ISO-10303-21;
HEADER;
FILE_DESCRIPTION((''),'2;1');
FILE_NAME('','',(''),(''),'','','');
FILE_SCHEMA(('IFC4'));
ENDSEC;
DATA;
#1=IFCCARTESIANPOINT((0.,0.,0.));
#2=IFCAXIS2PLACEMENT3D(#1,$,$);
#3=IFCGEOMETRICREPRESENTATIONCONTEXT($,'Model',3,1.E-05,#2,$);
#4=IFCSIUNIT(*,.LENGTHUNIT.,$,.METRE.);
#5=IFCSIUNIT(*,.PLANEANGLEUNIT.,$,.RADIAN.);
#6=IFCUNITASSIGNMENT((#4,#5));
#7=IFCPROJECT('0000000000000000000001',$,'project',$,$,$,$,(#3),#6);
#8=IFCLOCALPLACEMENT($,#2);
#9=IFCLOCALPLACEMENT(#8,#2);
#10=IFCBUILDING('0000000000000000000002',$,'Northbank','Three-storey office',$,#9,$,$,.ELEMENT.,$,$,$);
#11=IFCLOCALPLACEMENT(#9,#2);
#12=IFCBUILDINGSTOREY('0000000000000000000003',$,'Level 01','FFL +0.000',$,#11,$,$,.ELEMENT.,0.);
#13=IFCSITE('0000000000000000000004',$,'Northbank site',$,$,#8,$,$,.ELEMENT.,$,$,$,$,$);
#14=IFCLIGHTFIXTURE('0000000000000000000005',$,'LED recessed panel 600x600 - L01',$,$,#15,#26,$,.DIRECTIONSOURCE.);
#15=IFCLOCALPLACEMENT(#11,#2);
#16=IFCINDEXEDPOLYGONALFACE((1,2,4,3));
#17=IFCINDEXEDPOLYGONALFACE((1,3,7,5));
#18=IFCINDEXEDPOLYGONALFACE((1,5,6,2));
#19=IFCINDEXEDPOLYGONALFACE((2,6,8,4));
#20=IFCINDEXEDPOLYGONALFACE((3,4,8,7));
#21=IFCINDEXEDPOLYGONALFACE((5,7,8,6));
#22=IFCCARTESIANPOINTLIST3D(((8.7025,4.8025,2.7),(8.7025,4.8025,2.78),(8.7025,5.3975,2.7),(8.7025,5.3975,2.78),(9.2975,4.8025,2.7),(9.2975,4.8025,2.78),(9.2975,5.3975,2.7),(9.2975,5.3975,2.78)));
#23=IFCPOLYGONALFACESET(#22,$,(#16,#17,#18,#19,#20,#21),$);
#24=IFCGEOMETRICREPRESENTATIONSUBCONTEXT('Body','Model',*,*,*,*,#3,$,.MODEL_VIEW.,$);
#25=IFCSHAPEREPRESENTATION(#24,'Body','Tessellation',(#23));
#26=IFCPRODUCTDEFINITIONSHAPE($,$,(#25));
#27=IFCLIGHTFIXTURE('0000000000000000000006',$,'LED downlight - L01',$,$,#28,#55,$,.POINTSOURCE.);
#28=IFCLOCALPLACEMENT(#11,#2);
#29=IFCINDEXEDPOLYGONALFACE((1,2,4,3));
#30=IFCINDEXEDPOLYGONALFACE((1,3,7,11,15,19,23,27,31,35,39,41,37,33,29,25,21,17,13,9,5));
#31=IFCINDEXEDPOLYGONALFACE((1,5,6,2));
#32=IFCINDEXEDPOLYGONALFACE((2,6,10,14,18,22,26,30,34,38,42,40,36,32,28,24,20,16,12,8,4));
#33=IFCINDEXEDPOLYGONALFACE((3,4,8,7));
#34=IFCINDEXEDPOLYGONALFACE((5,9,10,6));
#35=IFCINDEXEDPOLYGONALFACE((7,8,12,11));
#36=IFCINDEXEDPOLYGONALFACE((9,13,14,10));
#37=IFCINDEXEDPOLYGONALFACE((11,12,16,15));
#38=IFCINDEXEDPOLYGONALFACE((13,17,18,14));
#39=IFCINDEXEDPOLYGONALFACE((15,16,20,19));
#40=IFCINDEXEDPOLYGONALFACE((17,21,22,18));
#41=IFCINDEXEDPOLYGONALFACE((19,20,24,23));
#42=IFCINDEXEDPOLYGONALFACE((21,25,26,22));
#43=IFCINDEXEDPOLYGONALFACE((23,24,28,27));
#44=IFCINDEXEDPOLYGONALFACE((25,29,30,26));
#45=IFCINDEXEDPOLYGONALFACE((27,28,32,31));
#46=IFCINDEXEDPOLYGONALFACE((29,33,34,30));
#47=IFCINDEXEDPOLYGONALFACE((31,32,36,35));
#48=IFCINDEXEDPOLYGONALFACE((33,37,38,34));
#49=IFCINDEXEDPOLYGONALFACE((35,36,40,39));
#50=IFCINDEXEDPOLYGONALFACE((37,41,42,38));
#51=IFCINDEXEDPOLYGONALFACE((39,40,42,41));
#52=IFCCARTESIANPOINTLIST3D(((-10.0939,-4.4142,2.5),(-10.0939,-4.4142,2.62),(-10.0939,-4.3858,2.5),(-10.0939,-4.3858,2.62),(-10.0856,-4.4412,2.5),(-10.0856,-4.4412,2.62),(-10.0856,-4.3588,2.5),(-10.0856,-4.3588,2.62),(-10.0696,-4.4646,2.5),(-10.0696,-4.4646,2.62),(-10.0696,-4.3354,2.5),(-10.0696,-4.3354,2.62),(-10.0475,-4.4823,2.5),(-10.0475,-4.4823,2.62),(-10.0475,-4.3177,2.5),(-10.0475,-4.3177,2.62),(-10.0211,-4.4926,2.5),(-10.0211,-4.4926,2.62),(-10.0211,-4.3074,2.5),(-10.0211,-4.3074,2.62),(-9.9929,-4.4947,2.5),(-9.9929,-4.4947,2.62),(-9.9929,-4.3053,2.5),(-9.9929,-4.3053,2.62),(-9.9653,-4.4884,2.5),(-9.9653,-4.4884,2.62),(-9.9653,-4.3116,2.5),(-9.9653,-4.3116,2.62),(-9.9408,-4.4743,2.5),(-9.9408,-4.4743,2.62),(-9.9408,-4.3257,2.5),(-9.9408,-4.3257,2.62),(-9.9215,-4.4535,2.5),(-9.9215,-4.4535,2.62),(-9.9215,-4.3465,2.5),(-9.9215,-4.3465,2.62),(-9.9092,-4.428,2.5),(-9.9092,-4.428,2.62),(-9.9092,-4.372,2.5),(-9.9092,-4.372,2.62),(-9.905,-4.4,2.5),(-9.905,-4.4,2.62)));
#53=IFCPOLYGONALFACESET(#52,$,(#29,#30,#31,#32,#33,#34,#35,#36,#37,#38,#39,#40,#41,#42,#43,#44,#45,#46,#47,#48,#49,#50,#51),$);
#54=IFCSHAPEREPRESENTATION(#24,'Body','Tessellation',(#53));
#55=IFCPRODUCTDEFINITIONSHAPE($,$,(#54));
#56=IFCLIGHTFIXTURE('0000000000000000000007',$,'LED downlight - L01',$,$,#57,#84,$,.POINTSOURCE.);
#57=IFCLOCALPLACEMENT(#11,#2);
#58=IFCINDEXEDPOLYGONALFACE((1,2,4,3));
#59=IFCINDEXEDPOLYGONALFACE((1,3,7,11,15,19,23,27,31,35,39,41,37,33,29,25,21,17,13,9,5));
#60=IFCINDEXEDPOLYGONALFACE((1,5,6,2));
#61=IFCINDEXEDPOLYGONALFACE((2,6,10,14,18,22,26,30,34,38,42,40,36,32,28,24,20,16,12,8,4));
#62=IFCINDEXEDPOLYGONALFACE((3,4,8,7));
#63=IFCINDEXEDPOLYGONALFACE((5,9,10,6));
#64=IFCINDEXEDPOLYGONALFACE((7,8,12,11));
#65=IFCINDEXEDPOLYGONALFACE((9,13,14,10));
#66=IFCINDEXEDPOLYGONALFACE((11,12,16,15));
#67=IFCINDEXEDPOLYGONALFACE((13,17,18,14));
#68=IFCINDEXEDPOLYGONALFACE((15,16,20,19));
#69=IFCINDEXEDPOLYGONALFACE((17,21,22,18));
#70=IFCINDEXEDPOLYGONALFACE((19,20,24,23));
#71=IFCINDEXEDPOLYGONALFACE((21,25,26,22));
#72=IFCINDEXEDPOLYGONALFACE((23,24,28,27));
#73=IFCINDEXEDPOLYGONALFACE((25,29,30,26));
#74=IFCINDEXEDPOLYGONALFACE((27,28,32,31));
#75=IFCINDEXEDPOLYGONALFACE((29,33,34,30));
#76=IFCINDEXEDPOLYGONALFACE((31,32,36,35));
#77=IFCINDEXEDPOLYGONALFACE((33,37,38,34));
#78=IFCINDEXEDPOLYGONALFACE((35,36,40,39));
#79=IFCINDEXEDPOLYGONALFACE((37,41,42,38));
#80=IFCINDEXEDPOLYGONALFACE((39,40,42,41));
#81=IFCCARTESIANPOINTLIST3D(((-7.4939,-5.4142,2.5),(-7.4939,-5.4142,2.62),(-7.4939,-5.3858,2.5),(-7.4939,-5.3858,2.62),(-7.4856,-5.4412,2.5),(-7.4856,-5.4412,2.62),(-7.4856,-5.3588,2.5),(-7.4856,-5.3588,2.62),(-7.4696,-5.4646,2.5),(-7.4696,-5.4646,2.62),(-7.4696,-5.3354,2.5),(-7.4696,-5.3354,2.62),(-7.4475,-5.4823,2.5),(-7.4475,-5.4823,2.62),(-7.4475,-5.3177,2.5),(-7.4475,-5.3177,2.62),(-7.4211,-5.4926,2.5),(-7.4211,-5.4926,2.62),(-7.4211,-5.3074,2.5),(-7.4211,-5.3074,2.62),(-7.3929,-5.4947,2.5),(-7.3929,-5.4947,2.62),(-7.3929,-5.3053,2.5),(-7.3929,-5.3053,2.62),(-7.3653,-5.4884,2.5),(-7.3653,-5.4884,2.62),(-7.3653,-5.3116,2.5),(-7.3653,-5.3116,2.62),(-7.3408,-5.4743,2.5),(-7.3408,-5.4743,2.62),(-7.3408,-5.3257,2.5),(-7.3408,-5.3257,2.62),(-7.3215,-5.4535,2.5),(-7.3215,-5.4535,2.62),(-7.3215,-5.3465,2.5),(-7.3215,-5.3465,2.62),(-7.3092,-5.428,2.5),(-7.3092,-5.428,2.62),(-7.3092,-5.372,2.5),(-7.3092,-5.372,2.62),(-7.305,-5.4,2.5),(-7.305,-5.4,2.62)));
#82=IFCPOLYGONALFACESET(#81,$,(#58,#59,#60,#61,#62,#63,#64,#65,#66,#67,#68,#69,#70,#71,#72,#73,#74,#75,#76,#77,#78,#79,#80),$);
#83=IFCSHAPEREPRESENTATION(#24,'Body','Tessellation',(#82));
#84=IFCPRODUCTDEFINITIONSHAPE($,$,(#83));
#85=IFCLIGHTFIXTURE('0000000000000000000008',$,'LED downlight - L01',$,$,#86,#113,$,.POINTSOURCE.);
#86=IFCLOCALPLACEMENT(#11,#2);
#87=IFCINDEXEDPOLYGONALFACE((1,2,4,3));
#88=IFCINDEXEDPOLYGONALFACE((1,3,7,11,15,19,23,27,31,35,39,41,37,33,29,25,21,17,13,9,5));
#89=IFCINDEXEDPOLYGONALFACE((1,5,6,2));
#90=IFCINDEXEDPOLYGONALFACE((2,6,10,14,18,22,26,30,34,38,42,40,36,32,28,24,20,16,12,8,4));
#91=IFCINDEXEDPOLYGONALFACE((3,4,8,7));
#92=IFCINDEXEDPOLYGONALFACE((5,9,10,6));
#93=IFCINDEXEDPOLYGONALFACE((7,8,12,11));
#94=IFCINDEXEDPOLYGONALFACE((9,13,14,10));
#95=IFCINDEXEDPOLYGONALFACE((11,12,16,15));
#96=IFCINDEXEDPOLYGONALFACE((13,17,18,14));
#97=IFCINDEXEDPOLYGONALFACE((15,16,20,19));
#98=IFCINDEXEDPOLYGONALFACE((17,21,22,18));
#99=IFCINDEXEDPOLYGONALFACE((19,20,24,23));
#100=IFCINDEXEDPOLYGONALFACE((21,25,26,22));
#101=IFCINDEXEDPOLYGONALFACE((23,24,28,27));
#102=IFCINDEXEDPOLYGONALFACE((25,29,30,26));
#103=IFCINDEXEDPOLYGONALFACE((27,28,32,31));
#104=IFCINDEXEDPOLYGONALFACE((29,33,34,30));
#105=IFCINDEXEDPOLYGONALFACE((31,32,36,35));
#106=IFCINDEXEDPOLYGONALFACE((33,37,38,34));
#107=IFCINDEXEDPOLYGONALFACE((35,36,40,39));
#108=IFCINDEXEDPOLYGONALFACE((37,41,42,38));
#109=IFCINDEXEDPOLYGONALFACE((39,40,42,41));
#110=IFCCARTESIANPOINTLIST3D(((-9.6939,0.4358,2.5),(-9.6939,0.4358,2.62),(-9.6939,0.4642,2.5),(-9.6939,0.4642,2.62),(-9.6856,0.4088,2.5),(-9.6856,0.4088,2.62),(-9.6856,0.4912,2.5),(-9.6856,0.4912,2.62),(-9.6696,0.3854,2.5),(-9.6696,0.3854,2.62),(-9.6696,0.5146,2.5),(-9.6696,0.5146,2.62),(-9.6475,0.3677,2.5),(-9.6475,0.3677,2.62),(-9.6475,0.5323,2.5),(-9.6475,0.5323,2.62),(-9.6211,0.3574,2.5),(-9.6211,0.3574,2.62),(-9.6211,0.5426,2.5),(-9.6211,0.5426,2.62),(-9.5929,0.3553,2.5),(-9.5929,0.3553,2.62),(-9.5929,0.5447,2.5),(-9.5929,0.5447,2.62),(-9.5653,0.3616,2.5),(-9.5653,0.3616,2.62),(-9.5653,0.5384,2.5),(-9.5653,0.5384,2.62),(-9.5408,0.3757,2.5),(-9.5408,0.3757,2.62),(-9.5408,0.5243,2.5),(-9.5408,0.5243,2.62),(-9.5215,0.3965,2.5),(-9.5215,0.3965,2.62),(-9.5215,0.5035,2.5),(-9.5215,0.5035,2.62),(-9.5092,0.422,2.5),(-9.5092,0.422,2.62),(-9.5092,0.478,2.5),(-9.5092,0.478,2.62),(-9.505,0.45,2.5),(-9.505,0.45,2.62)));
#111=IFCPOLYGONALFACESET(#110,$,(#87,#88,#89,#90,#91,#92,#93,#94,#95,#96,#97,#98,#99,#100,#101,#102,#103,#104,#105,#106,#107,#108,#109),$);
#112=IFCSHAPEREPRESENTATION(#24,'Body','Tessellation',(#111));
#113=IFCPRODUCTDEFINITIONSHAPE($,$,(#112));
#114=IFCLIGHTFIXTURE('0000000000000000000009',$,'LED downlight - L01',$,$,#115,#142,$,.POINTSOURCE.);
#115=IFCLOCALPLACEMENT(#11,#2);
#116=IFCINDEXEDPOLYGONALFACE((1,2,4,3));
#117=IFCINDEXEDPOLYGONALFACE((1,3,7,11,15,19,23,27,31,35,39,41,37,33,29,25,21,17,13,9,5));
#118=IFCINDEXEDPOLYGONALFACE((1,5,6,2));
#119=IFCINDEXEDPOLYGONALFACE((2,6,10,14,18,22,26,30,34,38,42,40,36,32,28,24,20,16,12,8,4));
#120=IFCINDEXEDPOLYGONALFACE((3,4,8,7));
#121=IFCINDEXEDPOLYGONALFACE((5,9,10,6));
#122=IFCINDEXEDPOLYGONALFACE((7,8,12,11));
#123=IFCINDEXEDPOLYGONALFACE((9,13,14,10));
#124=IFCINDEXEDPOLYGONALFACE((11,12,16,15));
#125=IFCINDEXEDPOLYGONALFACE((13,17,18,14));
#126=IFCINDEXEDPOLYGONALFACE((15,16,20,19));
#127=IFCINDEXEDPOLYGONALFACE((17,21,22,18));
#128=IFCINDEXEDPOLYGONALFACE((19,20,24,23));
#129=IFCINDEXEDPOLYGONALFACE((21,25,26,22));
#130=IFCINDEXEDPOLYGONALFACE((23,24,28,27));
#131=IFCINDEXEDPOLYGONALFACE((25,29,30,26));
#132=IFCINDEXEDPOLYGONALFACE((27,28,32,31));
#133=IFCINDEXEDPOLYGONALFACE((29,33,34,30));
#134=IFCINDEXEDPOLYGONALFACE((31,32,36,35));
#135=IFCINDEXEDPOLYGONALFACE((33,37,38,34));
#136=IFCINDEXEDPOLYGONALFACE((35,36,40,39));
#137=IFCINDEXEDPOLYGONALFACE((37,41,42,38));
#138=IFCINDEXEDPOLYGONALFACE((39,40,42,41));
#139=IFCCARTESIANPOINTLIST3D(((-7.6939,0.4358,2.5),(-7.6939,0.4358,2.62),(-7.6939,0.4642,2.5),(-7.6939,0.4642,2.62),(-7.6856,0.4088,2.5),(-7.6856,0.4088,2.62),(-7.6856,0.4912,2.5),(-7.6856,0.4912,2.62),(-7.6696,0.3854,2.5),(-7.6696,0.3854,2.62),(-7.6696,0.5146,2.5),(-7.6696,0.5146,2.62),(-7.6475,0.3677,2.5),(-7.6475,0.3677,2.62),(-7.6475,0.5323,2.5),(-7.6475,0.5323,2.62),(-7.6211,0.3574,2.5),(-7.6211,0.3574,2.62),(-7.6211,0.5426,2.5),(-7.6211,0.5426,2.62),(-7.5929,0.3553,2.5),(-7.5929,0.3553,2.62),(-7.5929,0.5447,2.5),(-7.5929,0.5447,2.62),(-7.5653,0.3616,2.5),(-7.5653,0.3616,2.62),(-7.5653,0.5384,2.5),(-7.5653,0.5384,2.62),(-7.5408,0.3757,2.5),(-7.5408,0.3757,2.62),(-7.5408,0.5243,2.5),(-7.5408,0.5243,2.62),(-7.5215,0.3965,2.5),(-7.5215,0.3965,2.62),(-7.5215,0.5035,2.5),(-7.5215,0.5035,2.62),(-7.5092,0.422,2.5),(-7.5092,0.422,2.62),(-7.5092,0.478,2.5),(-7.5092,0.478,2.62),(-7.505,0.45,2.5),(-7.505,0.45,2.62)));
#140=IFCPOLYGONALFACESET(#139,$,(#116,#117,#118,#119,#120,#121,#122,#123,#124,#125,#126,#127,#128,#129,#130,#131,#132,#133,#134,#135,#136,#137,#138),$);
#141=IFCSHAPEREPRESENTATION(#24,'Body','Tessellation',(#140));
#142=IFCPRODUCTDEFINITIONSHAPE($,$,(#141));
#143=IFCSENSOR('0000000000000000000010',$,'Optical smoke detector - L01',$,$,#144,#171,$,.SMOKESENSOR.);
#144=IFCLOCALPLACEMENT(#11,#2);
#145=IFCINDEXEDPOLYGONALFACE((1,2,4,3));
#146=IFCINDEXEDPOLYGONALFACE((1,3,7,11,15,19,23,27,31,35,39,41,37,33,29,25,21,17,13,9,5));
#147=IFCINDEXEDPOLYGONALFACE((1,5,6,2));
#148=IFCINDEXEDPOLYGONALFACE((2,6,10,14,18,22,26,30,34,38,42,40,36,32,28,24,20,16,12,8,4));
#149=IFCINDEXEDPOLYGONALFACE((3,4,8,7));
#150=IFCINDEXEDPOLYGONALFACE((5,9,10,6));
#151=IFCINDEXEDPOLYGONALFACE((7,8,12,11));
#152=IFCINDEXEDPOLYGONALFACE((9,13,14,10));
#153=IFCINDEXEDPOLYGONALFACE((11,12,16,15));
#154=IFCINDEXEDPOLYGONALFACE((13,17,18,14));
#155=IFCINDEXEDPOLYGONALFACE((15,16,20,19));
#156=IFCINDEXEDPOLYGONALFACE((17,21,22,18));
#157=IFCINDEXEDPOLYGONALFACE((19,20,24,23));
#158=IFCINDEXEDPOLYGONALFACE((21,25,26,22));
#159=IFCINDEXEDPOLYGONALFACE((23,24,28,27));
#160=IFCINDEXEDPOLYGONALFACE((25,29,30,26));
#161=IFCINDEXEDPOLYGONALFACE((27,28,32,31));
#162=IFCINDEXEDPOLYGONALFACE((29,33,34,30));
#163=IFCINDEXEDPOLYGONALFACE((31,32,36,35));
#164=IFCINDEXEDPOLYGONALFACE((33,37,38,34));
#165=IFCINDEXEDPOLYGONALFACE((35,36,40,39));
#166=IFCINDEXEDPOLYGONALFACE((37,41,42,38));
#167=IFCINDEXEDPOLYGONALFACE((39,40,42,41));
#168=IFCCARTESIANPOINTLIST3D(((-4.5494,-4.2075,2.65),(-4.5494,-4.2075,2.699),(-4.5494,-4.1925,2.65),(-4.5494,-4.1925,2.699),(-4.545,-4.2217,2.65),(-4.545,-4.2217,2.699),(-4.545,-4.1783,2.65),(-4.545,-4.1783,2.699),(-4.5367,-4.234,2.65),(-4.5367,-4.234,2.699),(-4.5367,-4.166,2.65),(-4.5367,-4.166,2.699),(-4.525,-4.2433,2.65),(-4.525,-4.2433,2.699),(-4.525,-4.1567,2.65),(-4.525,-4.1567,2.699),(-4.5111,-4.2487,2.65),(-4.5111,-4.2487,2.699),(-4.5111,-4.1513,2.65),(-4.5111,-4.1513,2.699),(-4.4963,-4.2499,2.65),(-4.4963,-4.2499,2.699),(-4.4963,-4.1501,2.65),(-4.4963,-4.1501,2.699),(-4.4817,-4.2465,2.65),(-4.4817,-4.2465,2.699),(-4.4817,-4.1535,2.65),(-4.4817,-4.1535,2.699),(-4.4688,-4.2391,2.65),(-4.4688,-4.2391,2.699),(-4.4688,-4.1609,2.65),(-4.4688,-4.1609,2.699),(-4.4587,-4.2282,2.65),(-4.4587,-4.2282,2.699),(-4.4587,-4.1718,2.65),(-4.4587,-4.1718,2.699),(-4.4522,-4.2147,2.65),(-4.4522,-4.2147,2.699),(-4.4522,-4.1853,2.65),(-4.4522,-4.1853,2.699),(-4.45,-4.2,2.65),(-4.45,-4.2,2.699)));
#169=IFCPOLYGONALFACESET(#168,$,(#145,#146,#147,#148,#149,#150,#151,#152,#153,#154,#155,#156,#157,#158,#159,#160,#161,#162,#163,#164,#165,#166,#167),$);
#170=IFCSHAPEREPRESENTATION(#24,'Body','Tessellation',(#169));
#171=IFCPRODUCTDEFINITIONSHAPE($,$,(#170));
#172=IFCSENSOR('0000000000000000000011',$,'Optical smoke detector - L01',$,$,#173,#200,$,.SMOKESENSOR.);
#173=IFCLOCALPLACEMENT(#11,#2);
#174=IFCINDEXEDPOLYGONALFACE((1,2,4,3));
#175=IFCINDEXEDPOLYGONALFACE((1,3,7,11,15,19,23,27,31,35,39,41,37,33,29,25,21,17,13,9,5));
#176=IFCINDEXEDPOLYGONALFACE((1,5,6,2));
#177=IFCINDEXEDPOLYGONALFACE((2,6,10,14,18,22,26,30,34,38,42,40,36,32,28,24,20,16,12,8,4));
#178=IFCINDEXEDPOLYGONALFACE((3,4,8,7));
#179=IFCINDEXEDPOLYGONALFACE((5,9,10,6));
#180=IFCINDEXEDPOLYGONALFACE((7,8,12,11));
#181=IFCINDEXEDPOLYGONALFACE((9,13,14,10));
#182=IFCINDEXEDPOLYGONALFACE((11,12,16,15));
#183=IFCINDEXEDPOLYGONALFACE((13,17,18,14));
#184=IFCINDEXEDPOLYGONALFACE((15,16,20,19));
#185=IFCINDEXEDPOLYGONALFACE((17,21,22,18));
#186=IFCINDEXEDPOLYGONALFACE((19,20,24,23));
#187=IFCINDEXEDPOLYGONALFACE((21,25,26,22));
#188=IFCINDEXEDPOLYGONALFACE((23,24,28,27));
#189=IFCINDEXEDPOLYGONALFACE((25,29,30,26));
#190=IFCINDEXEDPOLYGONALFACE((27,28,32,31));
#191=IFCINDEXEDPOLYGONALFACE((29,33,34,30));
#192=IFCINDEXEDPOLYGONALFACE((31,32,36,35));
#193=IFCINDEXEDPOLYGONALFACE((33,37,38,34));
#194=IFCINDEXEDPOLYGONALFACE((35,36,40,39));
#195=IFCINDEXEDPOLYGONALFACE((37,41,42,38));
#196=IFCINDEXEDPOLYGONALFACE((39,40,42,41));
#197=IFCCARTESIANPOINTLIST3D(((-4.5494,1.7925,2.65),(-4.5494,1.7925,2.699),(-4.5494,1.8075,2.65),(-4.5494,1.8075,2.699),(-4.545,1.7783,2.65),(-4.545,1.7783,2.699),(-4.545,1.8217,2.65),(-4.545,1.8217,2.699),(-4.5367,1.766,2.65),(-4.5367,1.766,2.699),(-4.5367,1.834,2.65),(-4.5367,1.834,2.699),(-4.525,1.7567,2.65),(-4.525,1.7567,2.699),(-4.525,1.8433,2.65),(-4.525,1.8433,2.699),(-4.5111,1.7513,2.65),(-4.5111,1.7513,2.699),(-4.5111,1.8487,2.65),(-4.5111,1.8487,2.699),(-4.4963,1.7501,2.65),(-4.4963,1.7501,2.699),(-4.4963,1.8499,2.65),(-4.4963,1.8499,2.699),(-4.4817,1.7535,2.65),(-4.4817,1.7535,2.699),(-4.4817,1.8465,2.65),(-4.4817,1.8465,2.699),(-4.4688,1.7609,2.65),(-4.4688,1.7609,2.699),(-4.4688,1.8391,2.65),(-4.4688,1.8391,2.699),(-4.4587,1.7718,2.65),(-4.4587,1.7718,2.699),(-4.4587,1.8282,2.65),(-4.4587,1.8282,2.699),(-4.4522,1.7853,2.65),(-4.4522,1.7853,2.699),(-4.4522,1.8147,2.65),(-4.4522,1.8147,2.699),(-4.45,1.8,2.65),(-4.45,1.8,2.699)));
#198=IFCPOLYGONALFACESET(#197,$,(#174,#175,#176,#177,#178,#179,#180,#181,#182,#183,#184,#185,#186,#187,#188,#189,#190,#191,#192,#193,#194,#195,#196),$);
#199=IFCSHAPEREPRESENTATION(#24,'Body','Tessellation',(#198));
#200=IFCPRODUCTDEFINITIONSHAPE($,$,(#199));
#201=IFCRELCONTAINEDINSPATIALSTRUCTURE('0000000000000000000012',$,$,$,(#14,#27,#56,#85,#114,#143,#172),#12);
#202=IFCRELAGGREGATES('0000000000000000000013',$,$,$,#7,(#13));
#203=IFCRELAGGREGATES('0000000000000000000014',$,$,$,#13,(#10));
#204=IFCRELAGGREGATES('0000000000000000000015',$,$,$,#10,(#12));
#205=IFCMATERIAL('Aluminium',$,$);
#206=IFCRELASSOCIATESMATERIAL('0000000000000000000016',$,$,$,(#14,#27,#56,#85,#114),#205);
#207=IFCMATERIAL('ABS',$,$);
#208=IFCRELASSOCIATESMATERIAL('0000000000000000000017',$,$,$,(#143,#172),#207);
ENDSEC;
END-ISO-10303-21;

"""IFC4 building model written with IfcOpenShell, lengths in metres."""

from ifc_helpers import new_model, si_unit, frame, origin, place, context, subcontext, project, spatial, rectangle, circle, extrude, material, element, save


model = new_model("IFC4")

# Units and contexts
model_context = context("Model", 3, precision=1e-05, world=origin())
body_context = subcontext(model_context, "Body", "Model", "MODEL_VIEW")
ifc_project = project(units=[si_unit("LENGTHUNIT", "METRE"), si_unit("PLANEANGLEUNIT", "RADIAN")], contexts=[model_context])

# Site, building, storey
site_placement = place(None, origin())
site = spatial("IfcSite", under=ifc_project, at=site_placement, Name="Northbank site", CompositionType="ELEMENT")
building_placement = place(site_placement, origin())
building = spatial("IfcBuilding", under=site, at=building_placement, Name="Northbank", Description="Three-storey office", CompositionType="ELEMENT")
storey_placement = place(building_placement, origin())
storey = spatial("IfcBuildingStorey", under=building, at=storey_placement, Name="Level 01", Description="FFL +0.000", CompositionType="ELEMENT", Elevation=0.0)

# Light fixtures
ifc_material_1 = material(Name="Aluminium")
light_fixture_1_placement = place(storey_placement, origin())
element("IfcLightFixture", 1, at=light_fixture_1_placement, inside=storey, material=ifc_material_1, Name="LED recessed panel 600x600 - L01", PredefinedType="DIRECTIONSOURCE", context=body_context, shape_type="SweptSolid", body=[
    extrude(rectangle(XDim=0.595, YDim=0.595), frame((9.0, 5.1, 2.7)), (0.0, 0.0, 1.0), 0.08),
])
light_fixture_2_placement = place(storey_placement, origin())
element("IfcLightFixture", 2, at=light_fixture_2_placement, inside=storey, material=ifc_material_1, Name="LED downlight - L01", PredefinedType="POINTSOURCE", context=body_context, shape_type="SweptSolid", body=[
    extrude(circle(Radius=0.095), frame((-10.0, -4.4, 2.5), z_axis=(0.0, 0.0, 1.0), x_axis=(1.0, 0.0, 0.0)), (0.0, 0.0, 1.0), 0.12),
])
light_fixture_3_placement = place(storey_placement, origin())
element("IfcLightFixture", 3, at=light_fixture_3_placement, inside=storey, material=ifc_material_1, Name="LED downlight - L01", PredefinedType="POINTSOURCE", context=body_context, shape_type="SweptSolid", body=[
    extrude(circle(Radius=0.095), frame((-7.4, -5.4, 2.5), z_axis=(0.0, 0.0, 1.0), x_axis=(1.0, 0.0, 0.0)), (0.0, 0.0, 1.0), 0.12),
])
light_fixture_4_placement = place(storey_placement, origin())
element("IfcLightFixture", 4, at=light_fixture_4_placement, inside=storey, material=ifc_material_1, Name="LED downlight - L01", PredefinedType="POINTSOURCE", context=body_context, shape_type="SweptSolid", body=[
    extrude(circle(Radius=0.095), frame((-9.6, 0.45, 2.5), z_axis=(0.0, 0.0, 1.0), x_axis=(1.0, 0.0, 0.0)), (0.0, 0.0, 1.0), 0.12),
])
light_fixture_5_placement = place(storey_placement, origin())
element("IfcLightFixture", 5, at=light_fixture_5_placement, inside=storey, material=ifc_material_1, Name="LED downlight - L01", PredefinedType="POINTSOURCE", context=body_context, shape_type="SweptSolid", body=[
    extrude(circle(Radius=0.095), frame((-7.6, 0.45, 2.5), z_axis=(0.0, 0.0, 1.0), x_axis=(1.0, 0.0, 0.0)), (0.0, 0.0, 1.0), 0.12),
])

# Sensors
ifc_material_2 = material(Name="ABS")
sensor_1_placement = place(storey_placement, origin())
element("IfcSensor", 6, at=sensor_1_placement, inside=storey, material=ifc_material_2, Name="Optical smoke detector - L01", PredefinedType="SMOKESENSOR", context=body_context, shape_type="SweptSolid", body=[
    extrude(circle(Radius=0.05), frame((-4.5, -4.2, 2.65), z_axis=(0.0, 0.0, 1.0), x_axis=(1.0, 0.0, 0.0)), (0.0, 0.0, 1.0), 0.049),
])
sensor_2_placement = place(storey_placement, origin())
element("IfcSensor", 7, at=sensor_2_placement, inside=storey, material=ifc_material_2, Name="Optical smoke detector - L01", PredefinedType="SMOKESENSOR", context=body_context, shape_type="SweptSolid", body=[
    extrude(circle(Radius=0.05), frame((-4.5, 1.8, 2.65), z_axis=(0.0, 0.0, 1.0), x_axis=(1.0, 0.0, 0.0)), (0.0, 0.0, 1.0), 0.049),
])

save(model, "model.ifc")
